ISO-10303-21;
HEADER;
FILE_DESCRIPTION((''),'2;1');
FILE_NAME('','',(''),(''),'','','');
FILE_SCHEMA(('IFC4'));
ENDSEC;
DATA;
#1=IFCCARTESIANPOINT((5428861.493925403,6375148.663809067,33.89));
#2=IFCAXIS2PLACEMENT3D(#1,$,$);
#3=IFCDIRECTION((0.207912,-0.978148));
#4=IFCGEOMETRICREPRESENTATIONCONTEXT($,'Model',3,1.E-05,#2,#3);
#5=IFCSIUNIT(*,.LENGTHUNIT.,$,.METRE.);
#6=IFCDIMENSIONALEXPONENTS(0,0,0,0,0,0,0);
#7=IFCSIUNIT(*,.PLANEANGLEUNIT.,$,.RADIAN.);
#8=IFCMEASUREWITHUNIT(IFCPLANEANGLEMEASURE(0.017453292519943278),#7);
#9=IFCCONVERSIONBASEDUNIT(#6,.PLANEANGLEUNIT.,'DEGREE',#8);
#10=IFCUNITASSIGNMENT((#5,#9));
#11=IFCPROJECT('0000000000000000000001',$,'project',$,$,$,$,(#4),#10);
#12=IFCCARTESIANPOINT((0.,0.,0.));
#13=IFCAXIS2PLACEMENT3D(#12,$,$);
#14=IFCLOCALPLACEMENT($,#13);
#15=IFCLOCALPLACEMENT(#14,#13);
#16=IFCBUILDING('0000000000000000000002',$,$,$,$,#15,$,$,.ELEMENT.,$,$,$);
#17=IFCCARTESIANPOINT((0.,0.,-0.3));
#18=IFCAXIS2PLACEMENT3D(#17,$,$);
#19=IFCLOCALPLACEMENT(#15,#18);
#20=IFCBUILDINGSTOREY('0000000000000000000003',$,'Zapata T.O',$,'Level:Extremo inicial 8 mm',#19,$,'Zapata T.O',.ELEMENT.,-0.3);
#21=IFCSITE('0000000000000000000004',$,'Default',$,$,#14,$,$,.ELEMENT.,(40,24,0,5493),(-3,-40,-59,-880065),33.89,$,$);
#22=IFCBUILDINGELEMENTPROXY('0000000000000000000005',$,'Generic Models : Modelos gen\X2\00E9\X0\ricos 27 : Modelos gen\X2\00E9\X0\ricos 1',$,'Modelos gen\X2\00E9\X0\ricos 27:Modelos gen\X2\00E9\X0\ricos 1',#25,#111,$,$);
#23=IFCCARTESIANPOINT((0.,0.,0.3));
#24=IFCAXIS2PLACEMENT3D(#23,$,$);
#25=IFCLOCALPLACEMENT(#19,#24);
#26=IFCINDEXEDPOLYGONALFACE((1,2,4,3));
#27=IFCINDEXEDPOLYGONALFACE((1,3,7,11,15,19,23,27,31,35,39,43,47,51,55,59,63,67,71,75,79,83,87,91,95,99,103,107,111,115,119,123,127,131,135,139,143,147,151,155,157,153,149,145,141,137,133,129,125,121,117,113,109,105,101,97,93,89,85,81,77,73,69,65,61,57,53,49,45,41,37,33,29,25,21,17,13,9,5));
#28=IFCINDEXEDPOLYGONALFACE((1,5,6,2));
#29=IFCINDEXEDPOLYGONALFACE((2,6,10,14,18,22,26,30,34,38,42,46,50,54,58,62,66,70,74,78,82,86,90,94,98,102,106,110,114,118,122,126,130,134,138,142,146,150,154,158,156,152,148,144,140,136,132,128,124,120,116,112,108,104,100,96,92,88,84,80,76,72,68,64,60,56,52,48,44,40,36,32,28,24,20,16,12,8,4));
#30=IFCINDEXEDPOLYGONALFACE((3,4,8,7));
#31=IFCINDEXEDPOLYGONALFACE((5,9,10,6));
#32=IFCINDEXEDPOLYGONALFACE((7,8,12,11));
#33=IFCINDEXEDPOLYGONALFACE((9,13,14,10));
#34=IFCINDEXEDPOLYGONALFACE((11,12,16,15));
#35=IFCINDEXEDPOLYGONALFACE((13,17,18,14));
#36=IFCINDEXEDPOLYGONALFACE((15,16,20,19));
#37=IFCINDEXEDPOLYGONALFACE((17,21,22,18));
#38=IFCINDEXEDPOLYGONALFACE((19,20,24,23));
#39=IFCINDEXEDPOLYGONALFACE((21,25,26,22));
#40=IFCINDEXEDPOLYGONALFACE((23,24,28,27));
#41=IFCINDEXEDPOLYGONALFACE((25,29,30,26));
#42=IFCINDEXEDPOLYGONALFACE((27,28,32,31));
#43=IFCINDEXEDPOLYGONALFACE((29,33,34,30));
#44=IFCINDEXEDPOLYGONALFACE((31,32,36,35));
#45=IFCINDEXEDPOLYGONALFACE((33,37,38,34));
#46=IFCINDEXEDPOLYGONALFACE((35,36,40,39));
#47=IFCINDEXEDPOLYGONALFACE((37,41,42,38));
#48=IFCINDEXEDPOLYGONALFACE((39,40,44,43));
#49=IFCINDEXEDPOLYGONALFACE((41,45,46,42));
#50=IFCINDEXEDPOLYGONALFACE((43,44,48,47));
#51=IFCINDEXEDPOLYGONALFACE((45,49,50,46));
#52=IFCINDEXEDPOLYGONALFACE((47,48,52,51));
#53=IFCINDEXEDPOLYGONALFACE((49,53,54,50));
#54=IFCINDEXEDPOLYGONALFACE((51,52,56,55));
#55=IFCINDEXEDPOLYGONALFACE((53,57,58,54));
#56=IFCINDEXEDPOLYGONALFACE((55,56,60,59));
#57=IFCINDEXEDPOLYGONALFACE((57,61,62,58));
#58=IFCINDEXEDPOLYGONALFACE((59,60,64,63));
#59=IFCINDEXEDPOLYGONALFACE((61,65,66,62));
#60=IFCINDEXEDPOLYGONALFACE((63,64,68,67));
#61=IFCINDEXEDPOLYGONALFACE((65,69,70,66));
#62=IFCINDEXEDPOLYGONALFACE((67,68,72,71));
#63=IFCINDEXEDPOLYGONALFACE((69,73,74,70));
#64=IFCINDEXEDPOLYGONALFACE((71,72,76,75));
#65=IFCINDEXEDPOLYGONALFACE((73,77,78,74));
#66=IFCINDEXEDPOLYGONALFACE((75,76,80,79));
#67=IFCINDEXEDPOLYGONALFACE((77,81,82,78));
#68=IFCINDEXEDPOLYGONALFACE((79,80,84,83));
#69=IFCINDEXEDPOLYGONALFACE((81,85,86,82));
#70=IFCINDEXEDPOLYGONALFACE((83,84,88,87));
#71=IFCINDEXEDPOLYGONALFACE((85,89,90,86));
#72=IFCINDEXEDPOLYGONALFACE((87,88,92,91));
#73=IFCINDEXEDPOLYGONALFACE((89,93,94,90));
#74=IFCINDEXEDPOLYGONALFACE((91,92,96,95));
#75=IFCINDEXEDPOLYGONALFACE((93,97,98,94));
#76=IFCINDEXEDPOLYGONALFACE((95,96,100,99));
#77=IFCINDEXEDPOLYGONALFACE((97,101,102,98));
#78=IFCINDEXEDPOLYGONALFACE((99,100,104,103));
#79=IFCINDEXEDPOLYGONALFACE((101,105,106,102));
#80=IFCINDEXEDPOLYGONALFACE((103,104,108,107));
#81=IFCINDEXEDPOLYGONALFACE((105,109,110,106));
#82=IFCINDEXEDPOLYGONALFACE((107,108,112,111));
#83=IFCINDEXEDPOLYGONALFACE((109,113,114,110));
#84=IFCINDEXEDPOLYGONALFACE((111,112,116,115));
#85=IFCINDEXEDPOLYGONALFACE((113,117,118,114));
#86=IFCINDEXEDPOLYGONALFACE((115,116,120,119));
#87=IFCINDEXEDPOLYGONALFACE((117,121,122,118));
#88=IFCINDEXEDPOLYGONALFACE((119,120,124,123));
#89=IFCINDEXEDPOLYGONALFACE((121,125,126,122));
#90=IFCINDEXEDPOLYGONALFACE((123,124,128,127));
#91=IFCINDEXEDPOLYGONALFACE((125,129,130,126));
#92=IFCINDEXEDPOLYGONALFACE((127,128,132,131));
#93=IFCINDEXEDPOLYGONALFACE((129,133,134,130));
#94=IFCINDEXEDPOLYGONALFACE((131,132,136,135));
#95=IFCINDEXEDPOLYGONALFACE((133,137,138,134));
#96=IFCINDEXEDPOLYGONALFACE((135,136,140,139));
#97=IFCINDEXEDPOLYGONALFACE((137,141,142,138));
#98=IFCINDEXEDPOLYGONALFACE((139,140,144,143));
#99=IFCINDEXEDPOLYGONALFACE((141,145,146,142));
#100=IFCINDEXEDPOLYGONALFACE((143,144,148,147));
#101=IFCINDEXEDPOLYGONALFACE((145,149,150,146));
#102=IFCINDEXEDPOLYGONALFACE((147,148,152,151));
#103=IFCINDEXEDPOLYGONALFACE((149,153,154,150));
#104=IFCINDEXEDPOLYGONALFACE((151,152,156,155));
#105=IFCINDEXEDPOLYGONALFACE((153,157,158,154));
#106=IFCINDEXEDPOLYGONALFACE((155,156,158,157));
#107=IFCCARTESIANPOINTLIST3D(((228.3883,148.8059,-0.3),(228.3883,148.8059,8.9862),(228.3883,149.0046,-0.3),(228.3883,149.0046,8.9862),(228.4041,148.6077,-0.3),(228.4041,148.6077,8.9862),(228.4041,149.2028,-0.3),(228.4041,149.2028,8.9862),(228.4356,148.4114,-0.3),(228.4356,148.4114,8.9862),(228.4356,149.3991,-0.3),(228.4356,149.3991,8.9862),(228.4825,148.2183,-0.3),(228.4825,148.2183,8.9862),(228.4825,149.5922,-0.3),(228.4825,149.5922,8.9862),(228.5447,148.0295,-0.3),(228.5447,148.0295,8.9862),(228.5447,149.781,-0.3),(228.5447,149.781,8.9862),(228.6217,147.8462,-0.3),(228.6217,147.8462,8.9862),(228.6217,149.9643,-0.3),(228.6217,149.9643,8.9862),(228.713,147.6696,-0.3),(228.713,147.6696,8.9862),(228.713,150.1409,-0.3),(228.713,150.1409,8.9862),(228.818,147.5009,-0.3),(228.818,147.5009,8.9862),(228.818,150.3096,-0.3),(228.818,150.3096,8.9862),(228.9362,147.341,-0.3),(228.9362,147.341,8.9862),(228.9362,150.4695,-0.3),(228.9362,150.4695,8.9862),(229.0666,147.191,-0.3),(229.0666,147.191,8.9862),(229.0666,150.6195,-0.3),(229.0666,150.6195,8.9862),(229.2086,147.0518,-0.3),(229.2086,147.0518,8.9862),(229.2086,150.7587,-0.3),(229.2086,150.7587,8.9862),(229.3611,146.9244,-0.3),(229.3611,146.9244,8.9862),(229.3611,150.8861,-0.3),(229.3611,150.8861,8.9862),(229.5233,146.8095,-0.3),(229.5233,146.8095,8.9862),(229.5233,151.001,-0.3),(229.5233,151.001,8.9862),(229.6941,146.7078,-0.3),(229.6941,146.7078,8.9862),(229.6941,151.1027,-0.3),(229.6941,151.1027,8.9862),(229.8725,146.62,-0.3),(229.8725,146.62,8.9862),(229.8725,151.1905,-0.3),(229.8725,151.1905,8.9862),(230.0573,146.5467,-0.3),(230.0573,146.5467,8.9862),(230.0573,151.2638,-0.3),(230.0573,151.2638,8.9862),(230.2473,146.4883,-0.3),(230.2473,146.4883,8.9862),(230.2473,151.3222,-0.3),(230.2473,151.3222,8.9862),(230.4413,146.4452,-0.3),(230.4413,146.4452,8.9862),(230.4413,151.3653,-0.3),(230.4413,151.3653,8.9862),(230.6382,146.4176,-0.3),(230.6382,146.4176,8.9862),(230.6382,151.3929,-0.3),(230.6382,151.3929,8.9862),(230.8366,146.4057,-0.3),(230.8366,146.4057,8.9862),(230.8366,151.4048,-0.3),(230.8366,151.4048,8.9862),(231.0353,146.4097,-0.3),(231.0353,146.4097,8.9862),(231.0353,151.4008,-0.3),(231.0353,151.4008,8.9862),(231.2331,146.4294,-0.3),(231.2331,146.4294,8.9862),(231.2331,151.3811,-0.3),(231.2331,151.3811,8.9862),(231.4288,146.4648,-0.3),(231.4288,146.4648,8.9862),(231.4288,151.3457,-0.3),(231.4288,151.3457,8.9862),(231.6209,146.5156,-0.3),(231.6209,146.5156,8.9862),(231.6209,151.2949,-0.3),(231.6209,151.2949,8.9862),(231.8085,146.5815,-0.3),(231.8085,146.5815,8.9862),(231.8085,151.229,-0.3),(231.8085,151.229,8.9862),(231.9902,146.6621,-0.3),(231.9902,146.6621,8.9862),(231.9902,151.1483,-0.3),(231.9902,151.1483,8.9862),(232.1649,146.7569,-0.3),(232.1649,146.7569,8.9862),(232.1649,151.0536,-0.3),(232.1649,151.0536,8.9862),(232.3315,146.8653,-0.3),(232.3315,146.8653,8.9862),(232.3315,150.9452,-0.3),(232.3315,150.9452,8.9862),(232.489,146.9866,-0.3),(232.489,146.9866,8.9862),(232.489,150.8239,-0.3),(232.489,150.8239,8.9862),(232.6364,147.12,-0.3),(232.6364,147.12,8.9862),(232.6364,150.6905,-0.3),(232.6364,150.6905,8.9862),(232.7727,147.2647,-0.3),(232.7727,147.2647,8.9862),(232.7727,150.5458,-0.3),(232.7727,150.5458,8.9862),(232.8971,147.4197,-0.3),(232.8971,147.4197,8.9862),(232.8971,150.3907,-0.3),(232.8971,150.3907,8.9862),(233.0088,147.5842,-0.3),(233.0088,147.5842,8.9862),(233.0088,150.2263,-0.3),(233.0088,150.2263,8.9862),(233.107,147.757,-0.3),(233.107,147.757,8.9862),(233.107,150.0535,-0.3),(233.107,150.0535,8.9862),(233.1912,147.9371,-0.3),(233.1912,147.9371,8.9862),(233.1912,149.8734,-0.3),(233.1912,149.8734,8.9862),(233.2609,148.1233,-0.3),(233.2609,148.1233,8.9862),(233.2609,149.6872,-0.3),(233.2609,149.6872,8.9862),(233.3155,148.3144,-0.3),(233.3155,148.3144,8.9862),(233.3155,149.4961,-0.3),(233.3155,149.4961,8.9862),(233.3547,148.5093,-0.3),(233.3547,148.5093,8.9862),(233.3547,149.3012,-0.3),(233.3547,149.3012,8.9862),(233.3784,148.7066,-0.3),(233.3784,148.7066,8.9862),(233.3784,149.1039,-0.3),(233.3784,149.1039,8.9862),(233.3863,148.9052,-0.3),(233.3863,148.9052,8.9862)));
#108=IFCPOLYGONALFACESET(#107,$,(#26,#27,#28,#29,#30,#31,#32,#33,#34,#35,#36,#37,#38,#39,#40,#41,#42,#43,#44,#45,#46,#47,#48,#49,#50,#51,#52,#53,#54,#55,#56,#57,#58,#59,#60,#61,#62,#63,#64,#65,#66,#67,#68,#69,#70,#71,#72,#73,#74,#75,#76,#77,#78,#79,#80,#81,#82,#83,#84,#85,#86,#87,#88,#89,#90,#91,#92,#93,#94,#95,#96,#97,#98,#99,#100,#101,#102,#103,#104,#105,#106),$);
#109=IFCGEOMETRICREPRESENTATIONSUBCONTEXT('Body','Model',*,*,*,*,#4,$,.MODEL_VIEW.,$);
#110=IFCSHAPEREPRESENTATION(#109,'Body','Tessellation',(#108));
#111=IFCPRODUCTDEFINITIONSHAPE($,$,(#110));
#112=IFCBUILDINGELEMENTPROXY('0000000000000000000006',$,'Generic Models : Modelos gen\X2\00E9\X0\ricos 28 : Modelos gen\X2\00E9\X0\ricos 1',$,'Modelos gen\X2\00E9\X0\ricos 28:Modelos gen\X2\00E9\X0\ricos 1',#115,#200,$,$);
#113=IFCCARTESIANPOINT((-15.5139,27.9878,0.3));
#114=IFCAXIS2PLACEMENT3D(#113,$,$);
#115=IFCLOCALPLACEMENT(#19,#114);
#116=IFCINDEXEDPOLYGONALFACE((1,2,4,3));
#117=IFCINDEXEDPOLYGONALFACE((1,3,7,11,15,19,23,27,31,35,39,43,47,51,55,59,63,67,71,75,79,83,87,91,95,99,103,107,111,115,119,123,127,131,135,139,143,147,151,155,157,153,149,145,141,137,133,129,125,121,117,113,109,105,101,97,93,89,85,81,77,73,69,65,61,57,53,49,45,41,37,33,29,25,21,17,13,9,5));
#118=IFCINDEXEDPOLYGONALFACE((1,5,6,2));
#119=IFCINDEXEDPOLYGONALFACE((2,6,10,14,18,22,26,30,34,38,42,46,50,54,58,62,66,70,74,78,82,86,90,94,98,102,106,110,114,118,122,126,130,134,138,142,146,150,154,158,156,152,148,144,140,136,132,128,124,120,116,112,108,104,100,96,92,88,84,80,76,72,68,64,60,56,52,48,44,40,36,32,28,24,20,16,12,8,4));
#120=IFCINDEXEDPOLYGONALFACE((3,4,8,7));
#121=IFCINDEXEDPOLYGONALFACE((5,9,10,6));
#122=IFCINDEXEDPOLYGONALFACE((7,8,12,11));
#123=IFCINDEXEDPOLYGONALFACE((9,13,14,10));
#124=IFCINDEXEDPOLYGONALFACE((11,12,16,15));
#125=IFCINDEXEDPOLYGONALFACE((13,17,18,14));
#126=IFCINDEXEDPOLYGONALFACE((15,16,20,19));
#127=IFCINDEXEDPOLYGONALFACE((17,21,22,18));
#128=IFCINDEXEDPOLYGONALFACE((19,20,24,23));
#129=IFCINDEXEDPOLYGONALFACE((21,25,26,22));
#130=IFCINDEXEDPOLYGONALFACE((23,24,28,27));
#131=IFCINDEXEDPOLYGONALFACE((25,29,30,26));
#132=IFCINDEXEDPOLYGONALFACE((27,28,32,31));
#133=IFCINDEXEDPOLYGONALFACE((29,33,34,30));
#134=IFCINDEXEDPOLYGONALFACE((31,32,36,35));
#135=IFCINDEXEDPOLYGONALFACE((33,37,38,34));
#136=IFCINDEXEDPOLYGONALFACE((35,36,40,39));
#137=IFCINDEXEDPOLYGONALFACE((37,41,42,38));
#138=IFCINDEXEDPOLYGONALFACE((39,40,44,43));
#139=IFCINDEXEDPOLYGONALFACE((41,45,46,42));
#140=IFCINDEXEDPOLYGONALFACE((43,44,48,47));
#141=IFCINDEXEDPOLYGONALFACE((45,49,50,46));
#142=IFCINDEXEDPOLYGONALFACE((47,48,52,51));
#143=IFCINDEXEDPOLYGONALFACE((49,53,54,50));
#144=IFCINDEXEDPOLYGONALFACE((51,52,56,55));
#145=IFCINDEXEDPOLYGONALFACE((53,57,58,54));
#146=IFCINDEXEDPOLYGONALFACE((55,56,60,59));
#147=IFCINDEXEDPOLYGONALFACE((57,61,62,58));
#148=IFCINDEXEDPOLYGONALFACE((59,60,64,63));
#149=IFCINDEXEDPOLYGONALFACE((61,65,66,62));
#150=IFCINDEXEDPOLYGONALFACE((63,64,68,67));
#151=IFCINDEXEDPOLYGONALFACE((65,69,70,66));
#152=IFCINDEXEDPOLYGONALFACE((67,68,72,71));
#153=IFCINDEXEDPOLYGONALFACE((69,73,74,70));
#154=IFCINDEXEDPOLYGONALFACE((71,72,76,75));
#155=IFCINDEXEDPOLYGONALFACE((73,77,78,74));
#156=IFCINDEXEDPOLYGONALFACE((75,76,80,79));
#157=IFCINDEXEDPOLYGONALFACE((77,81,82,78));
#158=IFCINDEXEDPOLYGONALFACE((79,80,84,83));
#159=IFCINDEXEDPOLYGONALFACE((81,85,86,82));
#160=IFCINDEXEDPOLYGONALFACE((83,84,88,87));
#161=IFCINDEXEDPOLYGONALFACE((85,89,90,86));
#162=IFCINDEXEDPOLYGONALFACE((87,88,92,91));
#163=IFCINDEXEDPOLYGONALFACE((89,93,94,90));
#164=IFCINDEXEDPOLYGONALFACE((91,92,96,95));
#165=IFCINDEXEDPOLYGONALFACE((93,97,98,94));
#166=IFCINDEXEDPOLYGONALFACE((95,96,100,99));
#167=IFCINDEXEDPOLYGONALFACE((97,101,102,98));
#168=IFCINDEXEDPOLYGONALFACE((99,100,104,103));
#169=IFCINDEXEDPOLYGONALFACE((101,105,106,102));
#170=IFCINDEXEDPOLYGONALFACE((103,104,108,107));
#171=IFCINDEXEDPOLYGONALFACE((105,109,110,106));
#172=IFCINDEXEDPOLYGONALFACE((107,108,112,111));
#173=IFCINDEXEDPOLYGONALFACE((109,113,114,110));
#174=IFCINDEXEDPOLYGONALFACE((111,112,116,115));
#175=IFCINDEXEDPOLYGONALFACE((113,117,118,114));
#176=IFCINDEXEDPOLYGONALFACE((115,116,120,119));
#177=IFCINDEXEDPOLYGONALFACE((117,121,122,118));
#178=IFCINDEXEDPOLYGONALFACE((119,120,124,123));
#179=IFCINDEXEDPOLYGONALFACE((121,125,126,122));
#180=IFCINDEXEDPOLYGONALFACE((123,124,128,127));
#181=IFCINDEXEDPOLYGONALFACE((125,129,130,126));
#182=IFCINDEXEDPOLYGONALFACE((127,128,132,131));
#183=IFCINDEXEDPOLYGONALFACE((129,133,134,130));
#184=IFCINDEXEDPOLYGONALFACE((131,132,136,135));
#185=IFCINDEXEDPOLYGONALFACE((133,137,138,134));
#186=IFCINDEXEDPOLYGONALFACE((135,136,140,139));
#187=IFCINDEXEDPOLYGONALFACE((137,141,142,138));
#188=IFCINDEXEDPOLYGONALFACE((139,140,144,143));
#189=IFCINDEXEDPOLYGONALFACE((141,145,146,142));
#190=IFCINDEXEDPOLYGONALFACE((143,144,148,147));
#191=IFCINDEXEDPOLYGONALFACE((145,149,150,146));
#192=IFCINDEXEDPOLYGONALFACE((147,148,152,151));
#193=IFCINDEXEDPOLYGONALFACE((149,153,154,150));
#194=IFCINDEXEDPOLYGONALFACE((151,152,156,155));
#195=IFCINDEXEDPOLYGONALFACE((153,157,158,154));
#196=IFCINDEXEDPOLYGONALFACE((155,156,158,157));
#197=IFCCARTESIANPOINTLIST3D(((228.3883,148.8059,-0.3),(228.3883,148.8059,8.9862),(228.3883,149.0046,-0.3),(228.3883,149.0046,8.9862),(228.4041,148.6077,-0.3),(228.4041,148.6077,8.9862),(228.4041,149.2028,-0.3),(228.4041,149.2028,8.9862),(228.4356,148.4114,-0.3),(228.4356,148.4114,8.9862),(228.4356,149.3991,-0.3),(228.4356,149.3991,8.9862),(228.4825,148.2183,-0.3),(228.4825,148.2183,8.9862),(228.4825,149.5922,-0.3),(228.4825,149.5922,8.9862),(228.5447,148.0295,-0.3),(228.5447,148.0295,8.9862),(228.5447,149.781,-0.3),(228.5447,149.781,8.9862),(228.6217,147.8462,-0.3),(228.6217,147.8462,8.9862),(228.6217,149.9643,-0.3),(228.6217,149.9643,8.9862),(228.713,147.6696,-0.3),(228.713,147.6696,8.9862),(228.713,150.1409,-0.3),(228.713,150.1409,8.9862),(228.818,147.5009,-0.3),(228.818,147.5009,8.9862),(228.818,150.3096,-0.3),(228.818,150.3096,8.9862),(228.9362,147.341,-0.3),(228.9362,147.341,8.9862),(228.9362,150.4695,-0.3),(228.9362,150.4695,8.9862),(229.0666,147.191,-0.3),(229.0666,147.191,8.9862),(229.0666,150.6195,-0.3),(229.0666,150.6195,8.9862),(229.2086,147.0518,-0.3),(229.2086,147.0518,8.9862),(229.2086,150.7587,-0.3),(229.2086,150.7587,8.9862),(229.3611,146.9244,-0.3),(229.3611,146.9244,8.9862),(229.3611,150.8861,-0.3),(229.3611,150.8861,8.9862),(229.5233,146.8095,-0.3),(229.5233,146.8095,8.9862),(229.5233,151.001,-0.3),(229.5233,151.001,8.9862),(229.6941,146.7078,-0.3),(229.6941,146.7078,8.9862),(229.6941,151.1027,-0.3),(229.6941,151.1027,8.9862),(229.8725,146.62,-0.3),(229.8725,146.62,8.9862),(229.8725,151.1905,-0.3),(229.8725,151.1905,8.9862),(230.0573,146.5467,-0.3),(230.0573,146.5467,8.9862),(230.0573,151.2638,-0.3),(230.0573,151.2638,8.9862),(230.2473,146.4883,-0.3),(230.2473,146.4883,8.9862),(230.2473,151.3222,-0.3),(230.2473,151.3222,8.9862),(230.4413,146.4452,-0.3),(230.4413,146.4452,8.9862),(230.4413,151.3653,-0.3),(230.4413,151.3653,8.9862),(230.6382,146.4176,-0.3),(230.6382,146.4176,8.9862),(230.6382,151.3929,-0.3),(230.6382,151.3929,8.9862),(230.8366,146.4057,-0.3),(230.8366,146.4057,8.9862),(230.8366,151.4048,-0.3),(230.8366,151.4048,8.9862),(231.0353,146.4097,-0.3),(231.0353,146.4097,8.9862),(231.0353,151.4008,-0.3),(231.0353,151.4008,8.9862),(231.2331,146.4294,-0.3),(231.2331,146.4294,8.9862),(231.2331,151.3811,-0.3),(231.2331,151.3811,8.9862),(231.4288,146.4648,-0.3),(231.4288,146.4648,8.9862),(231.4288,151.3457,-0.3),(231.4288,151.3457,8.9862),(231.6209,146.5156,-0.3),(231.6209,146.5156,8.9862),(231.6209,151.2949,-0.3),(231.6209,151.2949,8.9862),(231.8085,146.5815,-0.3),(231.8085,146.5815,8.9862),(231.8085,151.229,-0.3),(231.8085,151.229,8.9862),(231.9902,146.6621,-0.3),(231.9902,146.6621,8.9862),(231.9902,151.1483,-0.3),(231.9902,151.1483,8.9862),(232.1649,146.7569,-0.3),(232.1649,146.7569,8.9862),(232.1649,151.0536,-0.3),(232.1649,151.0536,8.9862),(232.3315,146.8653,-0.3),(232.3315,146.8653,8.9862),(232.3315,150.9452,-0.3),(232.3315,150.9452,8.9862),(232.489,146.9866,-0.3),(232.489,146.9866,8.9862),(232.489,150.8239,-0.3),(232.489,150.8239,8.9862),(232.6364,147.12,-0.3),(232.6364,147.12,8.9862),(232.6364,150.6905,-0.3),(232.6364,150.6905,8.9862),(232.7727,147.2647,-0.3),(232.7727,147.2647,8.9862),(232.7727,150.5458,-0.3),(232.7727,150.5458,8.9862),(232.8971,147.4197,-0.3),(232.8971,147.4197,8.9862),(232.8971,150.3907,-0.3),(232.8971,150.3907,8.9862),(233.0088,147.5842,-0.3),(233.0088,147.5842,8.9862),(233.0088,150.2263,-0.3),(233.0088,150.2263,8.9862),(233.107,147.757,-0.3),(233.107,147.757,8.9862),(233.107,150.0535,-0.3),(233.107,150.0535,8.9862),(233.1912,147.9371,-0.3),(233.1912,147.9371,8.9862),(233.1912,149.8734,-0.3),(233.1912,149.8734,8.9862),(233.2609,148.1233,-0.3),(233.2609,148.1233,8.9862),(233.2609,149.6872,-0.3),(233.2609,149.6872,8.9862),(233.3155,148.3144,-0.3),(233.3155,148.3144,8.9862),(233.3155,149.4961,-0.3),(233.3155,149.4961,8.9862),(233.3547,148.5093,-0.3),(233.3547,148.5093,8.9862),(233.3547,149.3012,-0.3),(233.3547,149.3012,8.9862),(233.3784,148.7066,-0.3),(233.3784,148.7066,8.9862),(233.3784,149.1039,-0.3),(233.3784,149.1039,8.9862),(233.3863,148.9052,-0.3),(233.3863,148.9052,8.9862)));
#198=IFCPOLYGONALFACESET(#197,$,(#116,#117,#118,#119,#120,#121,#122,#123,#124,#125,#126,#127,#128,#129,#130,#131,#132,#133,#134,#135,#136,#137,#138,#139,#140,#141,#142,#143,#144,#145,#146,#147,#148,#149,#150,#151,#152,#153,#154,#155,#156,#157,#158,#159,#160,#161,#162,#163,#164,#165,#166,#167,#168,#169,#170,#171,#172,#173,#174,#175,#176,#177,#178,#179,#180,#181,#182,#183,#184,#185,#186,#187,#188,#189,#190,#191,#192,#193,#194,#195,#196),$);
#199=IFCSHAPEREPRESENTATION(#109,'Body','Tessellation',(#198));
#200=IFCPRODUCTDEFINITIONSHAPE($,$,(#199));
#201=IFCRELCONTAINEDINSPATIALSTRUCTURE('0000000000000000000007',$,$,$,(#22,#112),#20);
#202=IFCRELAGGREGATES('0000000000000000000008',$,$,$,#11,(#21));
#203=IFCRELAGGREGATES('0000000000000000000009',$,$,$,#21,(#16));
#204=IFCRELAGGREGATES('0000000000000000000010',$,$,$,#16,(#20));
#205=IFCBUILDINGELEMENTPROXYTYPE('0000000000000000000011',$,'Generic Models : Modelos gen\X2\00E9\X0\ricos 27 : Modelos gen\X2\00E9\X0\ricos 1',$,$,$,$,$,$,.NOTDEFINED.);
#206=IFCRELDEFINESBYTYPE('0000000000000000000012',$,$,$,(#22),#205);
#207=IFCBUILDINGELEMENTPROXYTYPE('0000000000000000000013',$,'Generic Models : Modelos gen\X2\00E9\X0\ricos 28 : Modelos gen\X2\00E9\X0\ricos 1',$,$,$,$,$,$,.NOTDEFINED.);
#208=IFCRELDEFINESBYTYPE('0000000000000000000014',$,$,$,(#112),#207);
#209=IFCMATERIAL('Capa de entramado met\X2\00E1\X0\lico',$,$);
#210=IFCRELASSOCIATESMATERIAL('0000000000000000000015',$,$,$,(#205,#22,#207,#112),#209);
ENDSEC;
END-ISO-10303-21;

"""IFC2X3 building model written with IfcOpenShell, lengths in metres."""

from ifc_helpers import new_model, entity, si_unit, converted_unit, direction, frame, origin, origin_2d_with_axis, place, context, subcontext, project, spatial, circle, extrude, source, transform, mapped, material, type_object, type_shapes, element, save


model = new_model("IFC2X3")

# Units and contexts
model_context = context("Model", 3, precision=1e-05, world=frame((5428861.493925403, 6375148.663809067, 33.89)), true_north=direction((0.207912, -0.978148)))
body_context = subcontext(model_context, "Body", "Model", "MODEL_VIEW")
ifc_project = project(units=[si_unit("LENGTHUNIT", "METRE"), converted_unit("PLANEANGLEUNIT", "DEGREE", entity("IfcPlaneAngleMeasure", 0.017453292519943278), si_unit("PLANEANGLEUNIT", "RADIAN"), dimensions=[0, 0, 0, 0, 0, 0, 0])], contexts=[model_context])

# Site, building, storey
site_placement = place(None, origin())
site = spatial("IfcSite", under=ifc_project, at=site_placement, Name="Default", CompositionType="ELEMENT", RefLatitude=(40, 24, 0, 5493), RefLongitude=(-3, -40, -59, -880065), RefElevation=33.89)
building_placement = place(site_placement, origin())
building = spatial("IfcBuilding", under=site, at=building_placement, CompositionType="ELEMENT")
storey_placement = place(building_placement, frame((0.0, 0.0, -0.3)))
storey = spatial("IfcBuildingStorey", under=building, at=storey_placement, Name="Zapata T.O", ObjectType="Level:Extremo inicial 8 mm", LongName="Zapata T.O", CompositionType="ELEMENT", Elevation=-0.3)

# Building element proxies
ifc_material = material(Name="Capa de entramado metálico")
building_element_proxy_type_1 = type_object("IfcBuildingElementProxyType", Name="Generic Models : Modelos genéricos 27 : Modelos genéricos 1", PredefinedType="NOTDEFINED", material=ifc_material)
shared_shape_1 = source(origin(), body_context, "Body", "SweptSolid", [
    extrude(circle(Radius=2.5, at=origin_2d_with_axis()), frame((230.8863, 148.9052, -0.3)), (0.0, 0.0, 1.0), 9.2862),
])
type_shapes(building_element_proxy_type_1, [shared_shape_1])
proxy_1_placement = place(storey_placement, frame((0.0, 0.0, 0.3)))
element("IfcBuildingElementProxy", 1, at=proxy_1_placement, inside=storey, type_object=building_element_proxy_type_1, material=ifc_material, Name="Generic Models : Modelos genéricos 27 : Modelos genéricos 1", ObjectType="Modelos genéricos 27:Modelos genéricos 1", context=body_context, shape_type="MappedRepresentation", body=[
    mapped(shared_shape_1, transform((0.0, 0.0, 0.0), scale=1.0)),
])
building_element_proxy_type_2 = type_object("IfcBuildingElementProxyType", Name="Generic Models : Modelos genéricos 28 : Modelos genéricos 1", PredefinedType="NOTDEFINED", material=ifc_material)
shared_shape_2 = source(origin(), body_context, "Body", "SweptSolid", [
    extrude(circle(Radius=2.5, at=origin_2d_with_axis()), frame((230.8863, 148.9052, -0.3)), (0.0, 0.0, 1.0), 9.2862),
])
type_shapes(building_element_proxy_type_2, [shared_shape_2])
proxy_2_placement = place(storey_placement, frame((-15.5139, 27.9878, 0.3)))
element("IfcBuildingElementProxy", 2, at=proxy_2_placement, inside=storey, type_object=building_element_proxy_type_2, material=ifc_material, Name="Generic Models : Modelos genéricos 28 : Modelos genéricos 1", ObjectType="Modelos genéricos 28:Modelos genéricos 1", context=body_context, shape_type="MappedRepresentation", body=[
    mapped(shared_shape_2, transform((0.0, 0.0, 0.0), scale=1.0)),
])

save(model, "model.ifc")
